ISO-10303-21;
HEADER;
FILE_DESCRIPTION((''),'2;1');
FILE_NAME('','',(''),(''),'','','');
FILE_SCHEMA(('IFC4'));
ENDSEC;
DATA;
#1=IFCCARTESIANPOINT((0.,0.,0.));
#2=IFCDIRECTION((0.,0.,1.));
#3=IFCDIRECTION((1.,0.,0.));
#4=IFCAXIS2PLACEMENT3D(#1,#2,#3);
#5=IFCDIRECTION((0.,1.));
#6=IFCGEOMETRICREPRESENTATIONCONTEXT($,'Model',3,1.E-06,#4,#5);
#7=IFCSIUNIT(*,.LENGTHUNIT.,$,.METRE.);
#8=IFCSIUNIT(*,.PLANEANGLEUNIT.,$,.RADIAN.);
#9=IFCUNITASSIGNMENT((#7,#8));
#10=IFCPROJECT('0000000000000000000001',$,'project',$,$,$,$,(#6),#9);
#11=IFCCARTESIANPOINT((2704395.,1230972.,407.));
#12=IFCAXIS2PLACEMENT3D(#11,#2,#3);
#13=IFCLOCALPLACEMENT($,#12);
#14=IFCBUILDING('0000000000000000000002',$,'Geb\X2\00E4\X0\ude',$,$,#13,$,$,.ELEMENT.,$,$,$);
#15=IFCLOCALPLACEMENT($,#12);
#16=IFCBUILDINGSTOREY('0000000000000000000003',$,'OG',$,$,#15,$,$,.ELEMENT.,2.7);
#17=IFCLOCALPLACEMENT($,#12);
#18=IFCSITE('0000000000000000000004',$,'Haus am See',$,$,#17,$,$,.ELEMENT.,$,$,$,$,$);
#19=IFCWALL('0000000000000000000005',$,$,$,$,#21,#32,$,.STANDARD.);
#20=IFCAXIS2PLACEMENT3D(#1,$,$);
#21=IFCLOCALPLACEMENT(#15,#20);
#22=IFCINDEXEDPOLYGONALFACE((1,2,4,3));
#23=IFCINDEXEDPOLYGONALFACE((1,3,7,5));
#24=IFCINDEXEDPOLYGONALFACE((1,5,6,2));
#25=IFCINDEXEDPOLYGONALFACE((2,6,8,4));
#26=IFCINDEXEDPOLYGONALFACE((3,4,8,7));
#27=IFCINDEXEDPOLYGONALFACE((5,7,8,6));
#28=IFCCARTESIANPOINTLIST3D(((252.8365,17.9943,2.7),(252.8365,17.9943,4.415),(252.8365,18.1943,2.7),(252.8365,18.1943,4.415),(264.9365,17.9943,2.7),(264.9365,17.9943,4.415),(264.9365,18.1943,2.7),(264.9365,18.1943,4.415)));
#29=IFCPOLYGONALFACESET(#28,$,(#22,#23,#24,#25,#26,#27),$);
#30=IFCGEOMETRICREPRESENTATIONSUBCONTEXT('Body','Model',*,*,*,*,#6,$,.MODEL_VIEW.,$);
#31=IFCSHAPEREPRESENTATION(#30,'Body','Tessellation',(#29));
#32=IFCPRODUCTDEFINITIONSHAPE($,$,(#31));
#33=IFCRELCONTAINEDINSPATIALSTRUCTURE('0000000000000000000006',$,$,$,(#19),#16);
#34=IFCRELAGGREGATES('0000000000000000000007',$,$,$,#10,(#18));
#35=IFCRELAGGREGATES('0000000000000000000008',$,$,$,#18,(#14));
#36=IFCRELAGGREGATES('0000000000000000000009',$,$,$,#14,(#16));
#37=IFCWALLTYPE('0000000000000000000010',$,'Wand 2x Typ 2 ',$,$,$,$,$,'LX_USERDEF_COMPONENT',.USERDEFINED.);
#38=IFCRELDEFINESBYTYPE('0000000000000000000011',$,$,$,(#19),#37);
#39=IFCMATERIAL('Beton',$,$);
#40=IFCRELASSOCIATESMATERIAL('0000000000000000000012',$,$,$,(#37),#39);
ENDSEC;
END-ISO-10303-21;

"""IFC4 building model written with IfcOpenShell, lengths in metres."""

from ifc_helpers import new_model, si_unit, direction, frame, origin_with_axes, place, context, subcontext, project, spatial, polyline, outline, extrude, material, type_object, element, save


model = new_model("IFC4")

# Units and contexts
model_context = context("Model", 3, precision=1e-06, world=origin_with_axes(), true_north=direction((0.0, 1.0)))
body_context = subcontext(model_context, "Body", "Model", "MODEL_VIEW")
ifc_project = project(units=[si_unit("LENGTHUNIT", "METRE"), si_unit("PLANEANGLEUNIT", "RADIAN")], contexts=[model_context])

# Site, building, storey
site_placement = place(None, frame((2704395.0, 1230972.0, 407.0), z_axis=(0.0, 0.0, 1.0), x_axis=(1.0, 0.0, 0.0)))
site = spatial("IfcSite", under=ifc_project, at=site_placement, Name="Haus am See", CompositionType="ELEMENT")
building_placement = place(None, frame((2704395.0, 1230972.0, 407.0), z_axis=(0.0, 0.0, 1.0), x_axis=(1.0, 0.0, 0.0)))
building = spatial("IfcBuilding", under=site, at=building_placement, Name="Gebäude", CompositionType="ELEMENT")
storey_placement = place(None, frame((2704395.0, 1230972.0, 407.0), z_axis=(0.0, 0.0, 1.0), x_axis=(1.0, 0.0, 0.0)))
storey = spatial("IfcBuildingStorey", under=building, at=storey_placement, Name="OG", CompositionType="ELEMENT", Elevation=2.7)

# Wall
ifc_material_1 = material(Name="Beton")
wall_type = type_object("IfcWallType", Name="Wand 2x Typ 2 ", ElementType="LX_USERDEF_COMPONENT", PredefinedType="USERDEFINED", material=ifc_material_1)
wall_1_placement = place(storey_placement, frame((264.9365, 18.1943, 2.7), z_axis=(0.0, 0.0, 1.0), x_axis=(-1.0, 0.0, 0.0)))
element("IfcWall", 1, at=wall_1_placement, inside=storey, type_object=wall_type, PredefinedType="STANDARD", context=body_context, shape_type="SweptSolid", body=[
    extrude(outline(polyline([(0.0, 0.0, 0.0), (12.1, 0.0, 0.0), (12.1, 0.2, 0.0), (0.0, 0.2, 0.0), (0.0, 0.0, 0.0)])), origin_with_axes(), (0.0, 0.0, 1.0), 1.715),
])

save(model, "model.ifc")
